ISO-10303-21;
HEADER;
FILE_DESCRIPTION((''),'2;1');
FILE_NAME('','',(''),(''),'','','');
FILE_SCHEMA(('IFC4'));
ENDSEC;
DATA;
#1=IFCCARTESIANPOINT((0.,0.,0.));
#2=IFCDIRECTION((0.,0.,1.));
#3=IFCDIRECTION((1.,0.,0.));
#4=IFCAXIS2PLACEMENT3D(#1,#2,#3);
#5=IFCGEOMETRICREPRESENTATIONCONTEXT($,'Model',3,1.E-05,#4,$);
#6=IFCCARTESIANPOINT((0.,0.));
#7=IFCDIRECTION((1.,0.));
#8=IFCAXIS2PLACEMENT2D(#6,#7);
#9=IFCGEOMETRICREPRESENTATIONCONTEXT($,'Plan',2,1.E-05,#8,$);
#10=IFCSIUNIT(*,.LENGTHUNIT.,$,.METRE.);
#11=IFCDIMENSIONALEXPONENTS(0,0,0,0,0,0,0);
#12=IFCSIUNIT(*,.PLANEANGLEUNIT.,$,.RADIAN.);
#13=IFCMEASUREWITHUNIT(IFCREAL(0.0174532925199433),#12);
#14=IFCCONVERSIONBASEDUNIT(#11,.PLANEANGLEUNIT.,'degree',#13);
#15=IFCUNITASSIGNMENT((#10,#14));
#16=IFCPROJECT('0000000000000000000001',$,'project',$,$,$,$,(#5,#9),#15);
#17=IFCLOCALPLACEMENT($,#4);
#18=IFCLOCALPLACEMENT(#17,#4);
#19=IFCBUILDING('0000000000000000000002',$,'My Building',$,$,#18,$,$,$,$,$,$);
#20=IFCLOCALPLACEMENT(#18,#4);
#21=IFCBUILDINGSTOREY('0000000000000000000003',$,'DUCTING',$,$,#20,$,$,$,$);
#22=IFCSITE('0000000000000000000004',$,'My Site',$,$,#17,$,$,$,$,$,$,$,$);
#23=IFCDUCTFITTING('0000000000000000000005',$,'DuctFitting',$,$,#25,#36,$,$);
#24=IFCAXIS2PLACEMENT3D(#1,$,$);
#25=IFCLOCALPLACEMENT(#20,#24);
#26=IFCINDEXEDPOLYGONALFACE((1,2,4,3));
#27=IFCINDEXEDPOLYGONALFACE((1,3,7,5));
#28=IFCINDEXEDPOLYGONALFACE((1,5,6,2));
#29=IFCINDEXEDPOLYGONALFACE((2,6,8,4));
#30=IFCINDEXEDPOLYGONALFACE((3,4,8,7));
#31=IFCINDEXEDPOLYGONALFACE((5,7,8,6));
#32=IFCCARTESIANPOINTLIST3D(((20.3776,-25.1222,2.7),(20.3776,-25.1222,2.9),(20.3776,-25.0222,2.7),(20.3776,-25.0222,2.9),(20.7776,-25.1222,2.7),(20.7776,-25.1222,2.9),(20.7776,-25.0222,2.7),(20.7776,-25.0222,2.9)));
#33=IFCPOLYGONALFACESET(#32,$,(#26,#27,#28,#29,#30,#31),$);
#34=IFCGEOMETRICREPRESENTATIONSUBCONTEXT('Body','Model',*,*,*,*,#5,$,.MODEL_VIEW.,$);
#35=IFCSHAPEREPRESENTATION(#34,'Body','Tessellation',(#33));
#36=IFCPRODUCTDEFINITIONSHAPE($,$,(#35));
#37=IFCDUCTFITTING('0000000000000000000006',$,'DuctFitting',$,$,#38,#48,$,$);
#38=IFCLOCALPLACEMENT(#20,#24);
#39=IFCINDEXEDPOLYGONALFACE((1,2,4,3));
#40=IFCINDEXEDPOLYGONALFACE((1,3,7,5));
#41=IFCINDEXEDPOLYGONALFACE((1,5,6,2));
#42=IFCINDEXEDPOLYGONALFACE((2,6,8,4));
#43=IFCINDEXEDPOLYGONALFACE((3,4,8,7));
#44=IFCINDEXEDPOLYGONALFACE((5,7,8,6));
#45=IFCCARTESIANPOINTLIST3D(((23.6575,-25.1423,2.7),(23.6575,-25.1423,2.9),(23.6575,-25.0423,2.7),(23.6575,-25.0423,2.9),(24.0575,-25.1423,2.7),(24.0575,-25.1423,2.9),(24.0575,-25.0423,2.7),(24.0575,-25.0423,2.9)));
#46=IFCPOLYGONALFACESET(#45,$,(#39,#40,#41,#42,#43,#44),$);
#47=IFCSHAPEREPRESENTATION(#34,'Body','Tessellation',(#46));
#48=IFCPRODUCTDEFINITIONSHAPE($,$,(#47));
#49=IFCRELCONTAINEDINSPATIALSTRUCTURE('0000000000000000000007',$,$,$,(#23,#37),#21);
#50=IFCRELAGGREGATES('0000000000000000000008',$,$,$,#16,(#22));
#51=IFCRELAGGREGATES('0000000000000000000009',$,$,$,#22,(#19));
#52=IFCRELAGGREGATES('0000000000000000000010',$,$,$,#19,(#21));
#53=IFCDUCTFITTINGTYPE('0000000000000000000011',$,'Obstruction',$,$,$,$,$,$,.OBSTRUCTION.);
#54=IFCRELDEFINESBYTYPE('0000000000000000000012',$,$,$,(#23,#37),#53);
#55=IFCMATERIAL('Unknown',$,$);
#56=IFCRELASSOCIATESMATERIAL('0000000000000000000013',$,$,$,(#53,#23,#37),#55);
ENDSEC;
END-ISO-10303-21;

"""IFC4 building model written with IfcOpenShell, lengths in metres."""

from ifc_helpers import new_model, entity, si_unit, converted_unit, frame, origin_with_axes, origin_2d_with_axis, place, context, subcontext, project, spatial, rectangle, extrude, material, material_profile, profile_set, profile_usage, type_object, element, save


model = new_model("IFC4")

# Units and contexts
model_context = context("Model", 3, precision=1e-05, world=origin_with_axes())
plan_context = context("Plan", 2, precision=1e-05, world=origin_2d_with_axis())
body_context = subcontext(model_context, "Body", "Model", "MODEL_VIEW")
ifc_project = project(units=[si_unit("LENGTHUNIT", "METRE"), converted_unit("PLANEANGLEUNIT", "degree", entity("IfcReal", 0.0174532925199433), si_unit("PLANEANGLEUNIT", "RADIAN"), dimensions=[0, 0, 0, 0, 0, 0, 0])], contexts=[model_context, plan_context])

# Site, building, storey
site_placement = place(None, origin_with_axes())
site = spatial("IfcSite", under=ifc_project, at=site_placement, Name="My Site")
building_placement = place(site_placement, origin_with_axes())
building = spatial("IfcBuilding", under=site, at=building_placement, Name="My Building")
storey_placement = place(building_placement, origin_with_axes())
storey = spatial("IfcBuildingStorey", under=building, at=storey_placement, Name="DUCTING")

# Shared definitions
ifc_material = material(Name="Unknown")

# Duct fittings
ifc_material_profile_1 = material_profile(ifc_material, rectangle(XDim=0.4, YDim=0.2))
ifc_profile_set_1 = profile_set([ifc_material_profile_1])
duct_fitting_type_1 = type_object("IfcDuctFittingType", Name="Obstruction", PredefinedType="OBSTRUCTION", material=ifc_profile_set_1)
ifc_profile_usage_1 = profile_usage(ifc_profile_set_1, cardinal=5)
duct_fitting_1_placement = place(storey_placement, frame((20.5776, -25.1222, 2.8), z_axis=(0.0, 1.0, 0.0), x_axis=(-1.0, 0.0, 0.0)))
element("IfcDuctFitting", 1, at=duct_fitting_1_placement, inside=storey, type_object=duct_fitting_type_1, material=ifc_profile_usage_1, Name="DuctFitting", context=body_context, shape_type="SweptSolid", body=[
    extrude(rectangle(XDim=0.4, YDim=0.2), origin_with_axes(), (0.0, 0.0, 1.0), 0.1),
])
ifc_profile_usage_2 = profile_usage(ifc_profile_set_1, cardinal=5)
duct_fitting_2_placement = place(storey_placement, frame((23.8575, -25.1423, 2.8), z_axis=(0.0, 1.0, 0.0), x_axis=(-1.0, 0.0, 0.0)))
element("IfcDuctFitting", 2, at=duct_fitting_2_placement, inside=storey, type_object=duct_fitting_type_1, material=ifc_profile_usage_2, Name="DuctFitting", context=body_context, shape_type="SweptSolid", body=[
    extrude(rectangle(XDim=0.4, YDim=0.2), origin_with_axes(), (0.0, 0.0, 1.0), 0.1),
])

save(model, "model.ifc")
